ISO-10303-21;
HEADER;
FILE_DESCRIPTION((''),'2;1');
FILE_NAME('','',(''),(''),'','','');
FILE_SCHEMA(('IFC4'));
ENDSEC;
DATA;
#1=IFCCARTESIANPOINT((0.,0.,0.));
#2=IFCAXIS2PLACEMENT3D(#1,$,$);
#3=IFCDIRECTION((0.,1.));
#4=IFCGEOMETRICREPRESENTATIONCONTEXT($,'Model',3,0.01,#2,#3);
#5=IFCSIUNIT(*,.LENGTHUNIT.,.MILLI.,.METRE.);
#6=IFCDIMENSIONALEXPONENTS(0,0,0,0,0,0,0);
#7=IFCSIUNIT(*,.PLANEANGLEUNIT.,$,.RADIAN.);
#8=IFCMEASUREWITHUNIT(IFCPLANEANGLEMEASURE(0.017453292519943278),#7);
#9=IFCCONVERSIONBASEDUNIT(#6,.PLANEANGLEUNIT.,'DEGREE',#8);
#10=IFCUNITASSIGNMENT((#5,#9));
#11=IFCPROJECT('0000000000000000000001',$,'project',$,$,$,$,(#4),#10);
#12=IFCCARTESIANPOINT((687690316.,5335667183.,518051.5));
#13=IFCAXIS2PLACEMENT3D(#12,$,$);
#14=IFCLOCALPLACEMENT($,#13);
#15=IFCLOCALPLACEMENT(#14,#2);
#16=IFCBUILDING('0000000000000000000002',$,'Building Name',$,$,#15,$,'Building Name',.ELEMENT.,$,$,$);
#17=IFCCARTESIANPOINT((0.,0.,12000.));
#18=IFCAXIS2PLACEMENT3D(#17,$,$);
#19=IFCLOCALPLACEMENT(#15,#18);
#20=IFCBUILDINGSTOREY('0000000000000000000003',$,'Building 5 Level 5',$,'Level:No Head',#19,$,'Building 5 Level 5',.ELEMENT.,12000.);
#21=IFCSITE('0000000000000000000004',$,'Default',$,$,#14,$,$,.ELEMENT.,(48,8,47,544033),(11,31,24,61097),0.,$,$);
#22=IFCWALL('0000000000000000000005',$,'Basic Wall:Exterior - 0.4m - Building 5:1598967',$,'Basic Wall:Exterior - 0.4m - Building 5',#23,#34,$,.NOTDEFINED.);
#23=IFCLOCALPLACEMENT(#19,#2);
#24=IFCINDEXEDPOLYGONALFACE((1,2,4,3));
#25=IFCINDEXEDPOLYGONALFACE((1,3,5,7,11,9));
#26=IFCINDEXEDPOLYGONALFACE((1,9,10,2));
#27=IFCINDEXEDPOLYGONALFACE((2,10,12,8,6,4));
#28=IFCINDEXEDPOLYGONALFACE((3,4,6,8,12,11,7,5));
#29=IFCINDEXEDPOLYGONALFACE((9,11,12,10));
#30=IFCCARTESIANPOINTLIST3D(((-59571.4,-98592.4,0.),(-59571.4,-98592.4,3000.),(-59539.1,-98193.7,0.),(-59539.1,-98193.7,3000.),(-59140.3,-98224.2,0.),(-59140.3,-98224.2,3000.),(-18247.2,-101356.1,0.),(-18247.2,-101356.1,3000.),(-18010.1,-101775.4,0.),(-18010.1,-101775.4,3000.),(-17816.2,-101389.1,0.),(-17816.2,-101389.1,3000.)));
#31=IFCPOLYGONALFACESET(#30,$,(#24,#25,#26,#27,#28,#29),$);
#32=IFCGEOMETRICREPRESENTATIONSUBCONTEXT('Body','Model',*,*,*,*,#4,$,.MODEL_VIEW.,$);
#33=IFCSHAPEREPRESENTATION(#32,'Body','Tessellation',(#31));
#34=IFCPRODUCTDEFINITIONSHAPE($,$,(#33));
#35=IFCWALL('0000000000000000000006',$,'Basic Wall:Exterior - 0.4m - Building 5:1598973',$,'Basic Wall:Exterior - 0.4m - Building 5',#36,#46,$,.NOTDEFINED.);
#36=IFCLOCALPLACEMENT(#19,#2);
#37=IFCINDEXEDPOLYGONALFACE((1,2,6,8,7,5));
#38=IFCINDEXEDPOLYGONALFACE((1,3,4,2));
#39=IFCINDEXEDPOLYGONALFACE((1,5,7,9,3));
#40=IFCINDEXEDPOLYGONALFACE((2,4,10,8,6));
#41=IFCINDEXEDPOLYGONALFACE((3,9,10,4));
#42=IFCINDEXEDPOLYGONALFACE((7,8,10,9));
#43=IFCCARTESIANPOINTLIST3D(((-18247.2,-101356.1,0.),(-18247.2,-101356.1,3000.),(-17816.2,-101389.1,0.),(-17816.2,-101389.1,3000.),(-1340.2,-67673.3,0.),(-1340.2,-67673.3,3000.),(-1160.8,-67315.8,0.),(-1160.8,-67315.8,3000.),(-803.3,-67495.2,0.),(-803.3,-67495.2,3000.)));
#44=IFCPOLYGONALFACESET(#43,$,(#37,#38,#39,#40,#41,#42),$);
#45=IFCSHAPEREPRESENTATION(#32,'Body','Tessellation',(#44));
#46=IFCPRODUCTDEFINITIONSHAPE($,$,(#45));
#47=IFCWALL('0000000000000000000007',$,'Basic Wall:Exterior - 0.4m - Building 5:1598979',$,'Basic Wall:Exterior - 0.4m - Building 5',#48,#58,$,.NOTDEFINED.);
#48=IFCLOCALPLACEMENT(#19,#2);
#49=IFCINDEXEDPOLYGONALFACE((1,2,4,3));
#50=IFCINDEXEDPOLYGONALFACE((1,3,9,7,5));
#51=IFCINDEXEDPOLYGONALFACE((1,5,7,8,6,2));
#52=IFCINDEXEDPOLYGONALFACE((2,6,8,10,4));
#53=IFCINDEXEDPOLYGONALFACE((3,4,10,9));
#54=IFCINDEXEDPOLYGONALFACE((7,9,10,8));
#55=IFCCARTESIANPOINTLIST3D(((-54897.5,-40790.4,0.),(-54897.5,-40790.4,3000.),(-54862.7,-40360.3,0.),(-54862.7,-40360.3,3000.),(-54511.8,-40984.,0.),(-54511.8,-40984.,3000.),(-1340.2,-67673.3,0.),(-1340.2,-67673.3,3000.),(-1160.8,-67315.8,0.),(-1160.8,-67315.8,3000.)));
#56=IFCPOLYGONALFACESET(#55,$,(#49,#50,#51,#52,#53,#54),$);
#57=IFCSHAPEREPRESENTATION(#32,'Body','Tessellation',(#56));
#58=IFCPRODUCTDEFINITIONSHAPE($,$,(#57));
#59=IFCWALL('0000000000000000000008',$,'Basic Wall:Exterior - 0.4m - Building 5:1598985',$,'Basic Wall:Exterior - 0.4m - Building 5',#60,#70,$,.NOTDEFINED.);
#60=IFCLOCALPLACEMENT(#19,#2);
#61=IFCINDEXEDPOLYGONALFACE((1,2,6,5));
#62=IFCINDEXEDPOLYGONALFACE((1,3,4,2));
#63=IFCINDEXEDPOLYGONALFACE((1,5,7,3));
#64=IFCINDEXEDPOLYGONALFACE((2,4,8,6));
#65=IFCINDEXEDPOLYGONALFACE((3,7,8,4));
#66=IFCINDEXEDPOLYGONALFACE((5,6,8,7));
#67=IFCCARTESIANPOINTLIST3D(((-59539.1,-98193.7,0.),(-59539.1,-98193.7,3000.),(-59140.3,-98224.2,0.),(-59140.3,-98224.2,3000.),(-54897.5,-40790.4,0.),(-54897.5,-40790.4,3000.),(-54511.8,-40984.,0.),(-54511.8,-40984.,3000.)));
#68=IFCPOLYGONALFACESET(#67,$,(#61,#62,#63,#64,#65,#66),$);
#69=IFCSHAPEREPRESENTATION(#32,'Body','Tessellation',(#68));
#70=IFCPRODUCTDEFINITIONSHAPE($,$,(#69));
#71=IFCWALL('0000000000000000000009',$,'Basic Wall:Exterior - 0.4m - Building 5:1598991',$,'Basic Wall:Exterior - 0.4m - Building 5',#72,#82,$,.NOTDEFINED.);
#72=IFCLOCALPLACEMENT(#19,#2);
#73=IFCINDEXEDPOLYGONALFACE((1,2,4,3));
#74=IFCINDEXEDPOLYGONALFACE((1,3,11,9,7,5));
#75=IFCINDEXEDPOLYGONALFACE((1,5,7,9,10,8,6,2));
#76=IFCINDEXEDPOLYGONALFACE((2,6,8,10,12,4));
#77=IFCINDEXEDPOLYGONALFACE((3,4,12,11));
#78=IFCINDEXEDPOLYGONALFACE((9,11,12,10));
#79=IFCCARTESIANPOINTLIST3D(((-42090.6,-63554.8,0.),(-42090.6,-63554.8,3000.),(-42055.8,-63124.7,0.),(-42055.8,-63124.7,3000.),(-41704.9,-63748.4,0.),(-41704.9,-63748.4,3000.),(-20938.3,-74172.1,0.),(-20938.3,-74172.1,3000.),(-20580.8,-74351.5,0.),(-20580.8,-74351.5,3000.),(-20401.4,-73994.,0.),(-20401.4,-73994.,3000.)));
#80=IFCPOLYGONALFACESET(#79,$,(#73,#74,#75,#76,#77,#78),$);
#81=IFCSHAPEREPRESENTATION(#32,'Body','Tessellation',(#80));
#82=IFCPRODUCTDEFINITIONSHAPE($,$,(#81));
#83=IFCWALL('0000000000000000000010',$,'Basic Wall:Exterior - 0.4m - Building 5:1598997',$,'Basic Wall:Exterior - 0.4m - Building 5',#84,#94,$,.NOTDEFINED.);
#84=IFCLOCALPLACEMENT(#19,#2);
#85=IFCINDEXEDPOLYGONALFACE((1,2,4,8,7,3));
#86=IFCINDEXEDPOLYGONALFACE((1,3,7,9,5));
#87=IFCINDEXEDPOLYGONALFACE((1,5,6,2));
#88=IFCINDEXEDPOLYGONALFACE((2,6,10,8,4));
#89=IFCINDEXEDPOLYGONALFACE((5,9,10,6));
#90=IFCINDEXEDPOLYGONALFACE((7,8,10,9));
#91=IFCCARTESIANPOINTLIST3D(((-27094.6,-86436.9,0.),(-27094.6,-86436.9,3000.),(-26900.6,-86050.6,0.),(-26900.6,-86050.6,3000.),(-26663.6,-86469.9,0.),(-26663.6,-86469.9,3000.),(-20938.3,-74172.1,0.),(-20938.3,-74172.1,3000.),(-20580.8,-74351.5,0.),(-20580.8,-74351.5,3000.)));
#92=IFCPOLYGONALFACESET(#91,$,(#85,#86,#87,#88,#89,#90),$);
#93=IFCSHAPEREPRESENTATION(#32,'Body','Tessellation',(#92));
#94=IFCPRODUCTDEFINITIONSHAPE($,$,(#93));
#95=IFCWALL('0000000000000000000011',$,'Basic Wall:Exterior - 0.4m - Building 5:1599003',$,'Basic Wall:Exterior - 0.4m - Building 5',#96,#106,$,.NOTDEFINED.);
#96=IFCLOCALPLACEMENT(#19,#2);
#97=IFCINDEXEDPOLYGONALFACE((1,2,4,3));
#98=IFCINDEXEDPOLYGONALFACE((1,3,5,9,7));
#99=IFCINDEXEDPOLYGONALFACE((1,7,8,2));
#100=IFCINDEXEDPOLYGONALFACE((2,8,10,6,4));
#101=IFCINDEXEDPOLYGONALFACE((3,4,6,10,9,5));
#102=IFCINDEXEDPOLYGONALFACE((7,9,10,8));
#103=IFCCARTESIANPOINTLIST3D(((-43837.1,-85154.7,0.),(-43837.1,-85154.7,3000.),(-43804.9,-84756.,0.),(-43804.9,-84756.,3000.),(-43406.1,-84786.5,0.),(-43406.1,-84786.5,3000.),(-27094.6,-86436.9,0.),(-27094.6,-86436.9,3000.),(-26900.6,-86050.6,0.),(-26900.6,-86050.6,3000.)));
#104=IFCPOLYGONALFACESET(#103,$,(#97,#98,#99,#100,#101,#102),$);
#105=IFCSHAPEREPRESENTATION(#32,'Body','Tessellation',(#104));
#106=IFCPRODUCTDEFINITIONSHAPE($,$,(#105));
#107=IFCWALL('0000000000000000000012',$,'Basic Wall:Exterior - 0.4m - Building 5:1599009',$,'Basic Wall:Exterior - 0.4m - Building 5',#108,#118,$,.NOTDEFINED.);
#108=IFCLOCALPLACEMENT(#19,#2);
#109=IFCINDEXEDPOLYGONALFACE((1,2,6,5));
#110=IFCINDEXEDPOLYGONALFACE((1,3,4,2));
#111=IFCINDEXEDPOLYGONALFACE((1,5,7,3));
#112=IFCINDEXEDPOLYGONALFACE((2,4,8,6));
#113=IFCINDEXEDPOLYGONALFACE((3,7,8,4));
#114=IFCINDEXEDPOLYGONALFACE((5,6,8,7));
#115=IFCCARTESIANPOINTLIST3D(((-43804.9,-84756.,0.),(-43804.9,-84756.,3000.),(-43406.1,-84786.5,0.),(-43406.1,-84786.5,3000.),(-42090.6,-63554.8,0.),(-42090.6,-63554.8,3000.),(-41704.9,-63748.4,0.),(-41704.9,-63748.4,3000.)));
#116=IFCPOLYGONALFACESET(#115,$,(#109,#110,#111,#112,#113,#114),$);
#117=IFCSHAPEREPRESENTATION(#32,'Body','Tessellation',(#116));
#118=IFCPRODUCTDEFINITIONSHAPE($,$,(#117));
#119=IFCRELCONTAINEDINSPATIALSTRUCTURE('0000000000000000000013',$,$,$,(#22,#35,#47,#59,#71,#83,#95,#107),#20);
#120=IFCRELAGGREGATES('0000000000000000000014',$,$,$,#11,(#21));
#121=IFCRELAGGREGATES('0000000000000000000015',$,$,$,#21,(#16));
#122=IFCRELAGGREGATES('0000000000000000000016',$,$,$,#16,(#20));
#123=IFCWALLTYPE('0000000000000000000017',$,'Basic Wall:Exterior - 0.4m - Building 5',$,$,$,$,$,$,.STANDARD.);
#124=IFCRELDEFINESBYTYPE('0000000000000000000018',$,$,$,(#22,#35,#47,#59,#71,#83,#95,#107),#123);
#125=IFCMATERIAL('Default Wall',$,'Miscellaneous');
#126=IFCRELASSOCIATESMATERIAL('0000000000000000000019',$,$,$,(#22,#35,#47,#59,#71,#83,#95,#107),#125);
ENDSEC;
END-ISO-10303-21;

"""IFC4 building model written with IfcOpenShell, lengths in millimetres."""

from ifc_helpers import new_model, entity, si_unit, converted_unit, direction, frame, origin, place, context, subcontext, project, spatial, indexed_curve, outline, extrude, material, type_object, element, save


model = new_model("IFC4")

# Units and contexts
model_context = context("Model", 3, precision=0.01, world=origin(), true_north=direction((0.0, 1.0)))
body_context = subcontext(model_context, "Body", "Model", "MODEL_VIEW")
ifc_project = project(units=[si_unit("LENGTHUNIT", "METRE", prefix="MILLI"), converted_unit("PLANEANGLEUNIT", "DEGREE", entity("IfcPlaneAngleMeasure", 0.017453292519943278), si_unit("PLANEANGLEUNIT", "RADIAN"), dimensions=[0, 0, 0, 0, 0, 0, 0])], contexts=[model_context])

# Site, building, storey
site_placement = place(None, frame((687690316.0, 5335667183.0, 518051.5)))
site = spatial("IfcSite", under=ifc_project, at=site_placement, Name="Default", CompositionType="ELEMENT", RefLatitude=(48, 8, 47, 544033), RefLongitude=(11, 31, 24, 61097), RefElevation=0.0)
building_placement = place(site_placement, origin())
building = spatial("IfcBuilding", under=site, at=building_placement, Name="Building Name", LongName="Building Name", CompositionType="ELEMENT")
storey_placement = place(building_placement, frame((0.0, 0.0, 12000.0)))
storey = spatial("IfcBuildingStorey", under=building, at=storey_placement, Name="Building 5 Level 5", ObjectType="Level:No Head", LongName="Building 5 Level 5", CompositionType="ELEMENT", Elevation=12000.0)

# Walls
ifc_material_1 = material(Name="Default Wall", Category="Miscellaneous")
wall_type = type_object("IfcWallType", Name="Basic Wall:Exterior - 0.4m - Building 5", PredefinedType="STANDARD")
wall_1_placement = place(storey_placement, frame((-59556.1, -98393.0, 0.0), z_axis=(0.0, 0.0, 1.0), x_axis=(0.99708, -0.076363, 0.0)))
element("IfcWall", 1, at=wall_1_placement, inside=storey, type_object=wall_type, material=ifc_material_1, Name="Basic Wall:Exterior - 0.4m - Building 5:1598967", ObjectType="Basic Wall:Exterior - 0.4m - Building 5", PredefinedType="NOTDEFINED", context=body_context, shape_type="SweptSolid", body=[
    extrude(outline(indexed_curve([(41683.0, -200.0), (41846.9, 200.0), (41414.6, 200.0), (401.7, 200.0), (1.7, 200.0), (0.0, -200.0), (41683.0, -200.0)], self_intersect=False)), origin(), (0.0, 0.0, 1.0), 3000.0),
])
wall_2_placement = place(storey_placement, frame((-18068.4, -101445.8, 0.0), z_axis=(0.0, 0.0, 1.0), x_axis=(0.448604, 0.893731, 0.0)))
element("IfcWall", 2, at=wall_2_placement, inside=storey, type_object=wall_type, material=ifc_material_1, Name="Basic Wall:Exterior - 0.4m - Building 5:1598973", ObjectType="Basic Wall:Exterior - 0.4m - Building 5", PredefinedType="NOTDEFINED", context=body_context, shape_type="SweptSolid", body=[
    extrude(outline(indexed_curve([(38087.9, -200.0), (38087.9, 200.0), (37687.9, 200.0), (0.0, 200.0), (163.8, -200.0), (38087.9, -200.0)], self_intersect=False)), origin(), (0.0, 0.0, 1.0), 3000.0),
])
wall_3_placement = place(storey_placement, frame((-1250.5, -67494.5, 0.0), z_axis=(0.0, 0.0, 1.0), x_axis=(-0.893731, 0.448604, 0.0)))
element("IfcWall", 3, at=wall_3_placement, inside=storey, type_object=wall_type, material=ifc_material_1, Name="Basic Wall:Exterior - 0.4m - Building 5:1598979", ObjectType="Basic Wall:Exterior - 0.4m - Building 5", PredefinedType="NOTDEFINED", context=body_context, shape_type="SweptSolid", body=[
    extrude(outline(indexed_curve([(60087.4, -200.0), (59925.5, 200.0), (59494.0, 200.0), (0.0, 200.0), (0.0, -200.0), (60087.4, -200.0)], self_intersect=False)), origin(), (0.0, 0.0, 1.0), 3000.0),
])
wall_4_placement = place(storey_placement, frame((-54698.1, -40806.5, 0.0), z_axis=(0.0, 0.0, 1.0), x_axis=(-0.080597, -0.996747, 0.0)))
element("IfcWall", 4, at=wall_4_placement, inside=storey, type_object=wall_type, material=ifc_material_1, Name="Basic Wall:Exterior - 0.4m - Building 5:1598985", ObjectType="Basic Wall:Exterior - 0.4m - Building 5", PredefinedType="NOTDEFINED", context=body_context, shape_type="SweptSolid", body=[
    extrude(outline(indexed_curve([(57590.6, -200.0), (57588.9, 200.0), (161.9, 200.0), (0.0, -200.0), (57590.6, -200.0)], self_intersect=False)), origin(), (0.0, 0.0, 1.0), 3000.0),
])
wall_5_placement = place(storey_placement, frame((-42145.5, -63303.4, 0.0), z_axis=(0.0, 0.0, 1.0), x_axis=(0.893731, -0.448604, 0.0)))
element("IfcWall", 5, at=wall_5_placement, inside=storey, type_object=wall_type, material=ifc_material_1, Name="Basic Wall:Exterior - 0.4m - Building 5:1598991", ObjectType="Basic Wall:Exterior - 0.4m - Building 5", PredefinedType="NOTDEFINED", context=body_context, shape_type="SweptSolid", body=[
    extrude(outline(indexed_curve([(24229.3, -200.0), (24229.3, 200.0), (0.0, 200.0), (161.9, -200.0), (593.4, -200.0), (23829.3, -200.0), (24229.3, -200.0)], self_intersect=False)), origin(), (0.0, 0.0, 1.0), 3000.0),
])
wall_6_placement = place(storey_placement, frame((-20759.5, -74261.8, 0.0), z_axis=(0.0, 0.0, 1.0), x_axis=(-0.448604, -0.893731, 0.0)))
element("IfcWall", 6, at=wall_6_placement, inside=storey, type_object=wall_type, material=ifc_material_1, Name="Basic Wall:Exterior - 0.4m - Building 5:1598997", ObjectType="Basic Wall:Exterior - 0.4m - Building 5", PredefinedType="NOTDEFINED", context=body_context, shape_type="SweptSolid", body=[
    extrude(outline(indexed_curve([(13723.2, -200.0), (13559.3, 200.0), (0.0, 200.0), (0.0, -200.0), (13290.9, -200.0), (13723.2, -200.0)], self_intersect=False)), origin(), (0.0, 0.0, 1.0), 3000.0),
])
wall_7_placement = place(storey_placement, frame((-26915.9, -86250.0, 0.0), z_axis=(0.0, 0.0, 1.0), x_axis=(-0.99708, 0.076363, 0.0)))
element("IfcWall", 7, at=wall_7_placement, inside=storey, type_object=wall_type, material=ifc_material_1, Name="Basic Wall:Exterior - 0.4m - Building 5:1599003", ObjectType="Basic Wall:Exterior - 0.4m - Building 5", PredefinedType="NOTDEFINED", context=body_context, shape_type="SweptSolid", body=[
    extrude(outline(indexed_curve([(16953.8, -200.0), (16955.5, 200.0), (163.8, 200.0), (0.0, -200.0), (16553.8, -200.0), (16953.8, -200.0)], self_intersect=False)), origin(), (0.0, 0.0, 1.0), 3000.0),
])
wall_8_placement = place(storey_placement, frame((-43605.6, -84772.1, 0.0), z_axis=(0.0, 0.0, 1.0), x_axis=(0.080597, 0.996747, 0.0)))
element("IfcWall", 8, at=wall_8_placement, inside=storey, type_object=wall_type, material=ifc_material_1, Name="Basic Wall:Exterior - 0.4m - Building 5:1599009", ObjectType="Basic Wall:Exterior - 0.4m - Building 5", PredefinedType="NOTDEFINED", context=body_context, shape_type="SweptSolid", body=[
    extrude(outline(indexed_curve([(21108.5, -200.0), (21270.4, 200.0), (0.0, 200.0), (1.7, -200.0), (21108.5, -200.0)], self_intersect=False)), origin(), (0.0, 0.0, 1.0), 3000.0),
])

save(model, "model.ifc")
